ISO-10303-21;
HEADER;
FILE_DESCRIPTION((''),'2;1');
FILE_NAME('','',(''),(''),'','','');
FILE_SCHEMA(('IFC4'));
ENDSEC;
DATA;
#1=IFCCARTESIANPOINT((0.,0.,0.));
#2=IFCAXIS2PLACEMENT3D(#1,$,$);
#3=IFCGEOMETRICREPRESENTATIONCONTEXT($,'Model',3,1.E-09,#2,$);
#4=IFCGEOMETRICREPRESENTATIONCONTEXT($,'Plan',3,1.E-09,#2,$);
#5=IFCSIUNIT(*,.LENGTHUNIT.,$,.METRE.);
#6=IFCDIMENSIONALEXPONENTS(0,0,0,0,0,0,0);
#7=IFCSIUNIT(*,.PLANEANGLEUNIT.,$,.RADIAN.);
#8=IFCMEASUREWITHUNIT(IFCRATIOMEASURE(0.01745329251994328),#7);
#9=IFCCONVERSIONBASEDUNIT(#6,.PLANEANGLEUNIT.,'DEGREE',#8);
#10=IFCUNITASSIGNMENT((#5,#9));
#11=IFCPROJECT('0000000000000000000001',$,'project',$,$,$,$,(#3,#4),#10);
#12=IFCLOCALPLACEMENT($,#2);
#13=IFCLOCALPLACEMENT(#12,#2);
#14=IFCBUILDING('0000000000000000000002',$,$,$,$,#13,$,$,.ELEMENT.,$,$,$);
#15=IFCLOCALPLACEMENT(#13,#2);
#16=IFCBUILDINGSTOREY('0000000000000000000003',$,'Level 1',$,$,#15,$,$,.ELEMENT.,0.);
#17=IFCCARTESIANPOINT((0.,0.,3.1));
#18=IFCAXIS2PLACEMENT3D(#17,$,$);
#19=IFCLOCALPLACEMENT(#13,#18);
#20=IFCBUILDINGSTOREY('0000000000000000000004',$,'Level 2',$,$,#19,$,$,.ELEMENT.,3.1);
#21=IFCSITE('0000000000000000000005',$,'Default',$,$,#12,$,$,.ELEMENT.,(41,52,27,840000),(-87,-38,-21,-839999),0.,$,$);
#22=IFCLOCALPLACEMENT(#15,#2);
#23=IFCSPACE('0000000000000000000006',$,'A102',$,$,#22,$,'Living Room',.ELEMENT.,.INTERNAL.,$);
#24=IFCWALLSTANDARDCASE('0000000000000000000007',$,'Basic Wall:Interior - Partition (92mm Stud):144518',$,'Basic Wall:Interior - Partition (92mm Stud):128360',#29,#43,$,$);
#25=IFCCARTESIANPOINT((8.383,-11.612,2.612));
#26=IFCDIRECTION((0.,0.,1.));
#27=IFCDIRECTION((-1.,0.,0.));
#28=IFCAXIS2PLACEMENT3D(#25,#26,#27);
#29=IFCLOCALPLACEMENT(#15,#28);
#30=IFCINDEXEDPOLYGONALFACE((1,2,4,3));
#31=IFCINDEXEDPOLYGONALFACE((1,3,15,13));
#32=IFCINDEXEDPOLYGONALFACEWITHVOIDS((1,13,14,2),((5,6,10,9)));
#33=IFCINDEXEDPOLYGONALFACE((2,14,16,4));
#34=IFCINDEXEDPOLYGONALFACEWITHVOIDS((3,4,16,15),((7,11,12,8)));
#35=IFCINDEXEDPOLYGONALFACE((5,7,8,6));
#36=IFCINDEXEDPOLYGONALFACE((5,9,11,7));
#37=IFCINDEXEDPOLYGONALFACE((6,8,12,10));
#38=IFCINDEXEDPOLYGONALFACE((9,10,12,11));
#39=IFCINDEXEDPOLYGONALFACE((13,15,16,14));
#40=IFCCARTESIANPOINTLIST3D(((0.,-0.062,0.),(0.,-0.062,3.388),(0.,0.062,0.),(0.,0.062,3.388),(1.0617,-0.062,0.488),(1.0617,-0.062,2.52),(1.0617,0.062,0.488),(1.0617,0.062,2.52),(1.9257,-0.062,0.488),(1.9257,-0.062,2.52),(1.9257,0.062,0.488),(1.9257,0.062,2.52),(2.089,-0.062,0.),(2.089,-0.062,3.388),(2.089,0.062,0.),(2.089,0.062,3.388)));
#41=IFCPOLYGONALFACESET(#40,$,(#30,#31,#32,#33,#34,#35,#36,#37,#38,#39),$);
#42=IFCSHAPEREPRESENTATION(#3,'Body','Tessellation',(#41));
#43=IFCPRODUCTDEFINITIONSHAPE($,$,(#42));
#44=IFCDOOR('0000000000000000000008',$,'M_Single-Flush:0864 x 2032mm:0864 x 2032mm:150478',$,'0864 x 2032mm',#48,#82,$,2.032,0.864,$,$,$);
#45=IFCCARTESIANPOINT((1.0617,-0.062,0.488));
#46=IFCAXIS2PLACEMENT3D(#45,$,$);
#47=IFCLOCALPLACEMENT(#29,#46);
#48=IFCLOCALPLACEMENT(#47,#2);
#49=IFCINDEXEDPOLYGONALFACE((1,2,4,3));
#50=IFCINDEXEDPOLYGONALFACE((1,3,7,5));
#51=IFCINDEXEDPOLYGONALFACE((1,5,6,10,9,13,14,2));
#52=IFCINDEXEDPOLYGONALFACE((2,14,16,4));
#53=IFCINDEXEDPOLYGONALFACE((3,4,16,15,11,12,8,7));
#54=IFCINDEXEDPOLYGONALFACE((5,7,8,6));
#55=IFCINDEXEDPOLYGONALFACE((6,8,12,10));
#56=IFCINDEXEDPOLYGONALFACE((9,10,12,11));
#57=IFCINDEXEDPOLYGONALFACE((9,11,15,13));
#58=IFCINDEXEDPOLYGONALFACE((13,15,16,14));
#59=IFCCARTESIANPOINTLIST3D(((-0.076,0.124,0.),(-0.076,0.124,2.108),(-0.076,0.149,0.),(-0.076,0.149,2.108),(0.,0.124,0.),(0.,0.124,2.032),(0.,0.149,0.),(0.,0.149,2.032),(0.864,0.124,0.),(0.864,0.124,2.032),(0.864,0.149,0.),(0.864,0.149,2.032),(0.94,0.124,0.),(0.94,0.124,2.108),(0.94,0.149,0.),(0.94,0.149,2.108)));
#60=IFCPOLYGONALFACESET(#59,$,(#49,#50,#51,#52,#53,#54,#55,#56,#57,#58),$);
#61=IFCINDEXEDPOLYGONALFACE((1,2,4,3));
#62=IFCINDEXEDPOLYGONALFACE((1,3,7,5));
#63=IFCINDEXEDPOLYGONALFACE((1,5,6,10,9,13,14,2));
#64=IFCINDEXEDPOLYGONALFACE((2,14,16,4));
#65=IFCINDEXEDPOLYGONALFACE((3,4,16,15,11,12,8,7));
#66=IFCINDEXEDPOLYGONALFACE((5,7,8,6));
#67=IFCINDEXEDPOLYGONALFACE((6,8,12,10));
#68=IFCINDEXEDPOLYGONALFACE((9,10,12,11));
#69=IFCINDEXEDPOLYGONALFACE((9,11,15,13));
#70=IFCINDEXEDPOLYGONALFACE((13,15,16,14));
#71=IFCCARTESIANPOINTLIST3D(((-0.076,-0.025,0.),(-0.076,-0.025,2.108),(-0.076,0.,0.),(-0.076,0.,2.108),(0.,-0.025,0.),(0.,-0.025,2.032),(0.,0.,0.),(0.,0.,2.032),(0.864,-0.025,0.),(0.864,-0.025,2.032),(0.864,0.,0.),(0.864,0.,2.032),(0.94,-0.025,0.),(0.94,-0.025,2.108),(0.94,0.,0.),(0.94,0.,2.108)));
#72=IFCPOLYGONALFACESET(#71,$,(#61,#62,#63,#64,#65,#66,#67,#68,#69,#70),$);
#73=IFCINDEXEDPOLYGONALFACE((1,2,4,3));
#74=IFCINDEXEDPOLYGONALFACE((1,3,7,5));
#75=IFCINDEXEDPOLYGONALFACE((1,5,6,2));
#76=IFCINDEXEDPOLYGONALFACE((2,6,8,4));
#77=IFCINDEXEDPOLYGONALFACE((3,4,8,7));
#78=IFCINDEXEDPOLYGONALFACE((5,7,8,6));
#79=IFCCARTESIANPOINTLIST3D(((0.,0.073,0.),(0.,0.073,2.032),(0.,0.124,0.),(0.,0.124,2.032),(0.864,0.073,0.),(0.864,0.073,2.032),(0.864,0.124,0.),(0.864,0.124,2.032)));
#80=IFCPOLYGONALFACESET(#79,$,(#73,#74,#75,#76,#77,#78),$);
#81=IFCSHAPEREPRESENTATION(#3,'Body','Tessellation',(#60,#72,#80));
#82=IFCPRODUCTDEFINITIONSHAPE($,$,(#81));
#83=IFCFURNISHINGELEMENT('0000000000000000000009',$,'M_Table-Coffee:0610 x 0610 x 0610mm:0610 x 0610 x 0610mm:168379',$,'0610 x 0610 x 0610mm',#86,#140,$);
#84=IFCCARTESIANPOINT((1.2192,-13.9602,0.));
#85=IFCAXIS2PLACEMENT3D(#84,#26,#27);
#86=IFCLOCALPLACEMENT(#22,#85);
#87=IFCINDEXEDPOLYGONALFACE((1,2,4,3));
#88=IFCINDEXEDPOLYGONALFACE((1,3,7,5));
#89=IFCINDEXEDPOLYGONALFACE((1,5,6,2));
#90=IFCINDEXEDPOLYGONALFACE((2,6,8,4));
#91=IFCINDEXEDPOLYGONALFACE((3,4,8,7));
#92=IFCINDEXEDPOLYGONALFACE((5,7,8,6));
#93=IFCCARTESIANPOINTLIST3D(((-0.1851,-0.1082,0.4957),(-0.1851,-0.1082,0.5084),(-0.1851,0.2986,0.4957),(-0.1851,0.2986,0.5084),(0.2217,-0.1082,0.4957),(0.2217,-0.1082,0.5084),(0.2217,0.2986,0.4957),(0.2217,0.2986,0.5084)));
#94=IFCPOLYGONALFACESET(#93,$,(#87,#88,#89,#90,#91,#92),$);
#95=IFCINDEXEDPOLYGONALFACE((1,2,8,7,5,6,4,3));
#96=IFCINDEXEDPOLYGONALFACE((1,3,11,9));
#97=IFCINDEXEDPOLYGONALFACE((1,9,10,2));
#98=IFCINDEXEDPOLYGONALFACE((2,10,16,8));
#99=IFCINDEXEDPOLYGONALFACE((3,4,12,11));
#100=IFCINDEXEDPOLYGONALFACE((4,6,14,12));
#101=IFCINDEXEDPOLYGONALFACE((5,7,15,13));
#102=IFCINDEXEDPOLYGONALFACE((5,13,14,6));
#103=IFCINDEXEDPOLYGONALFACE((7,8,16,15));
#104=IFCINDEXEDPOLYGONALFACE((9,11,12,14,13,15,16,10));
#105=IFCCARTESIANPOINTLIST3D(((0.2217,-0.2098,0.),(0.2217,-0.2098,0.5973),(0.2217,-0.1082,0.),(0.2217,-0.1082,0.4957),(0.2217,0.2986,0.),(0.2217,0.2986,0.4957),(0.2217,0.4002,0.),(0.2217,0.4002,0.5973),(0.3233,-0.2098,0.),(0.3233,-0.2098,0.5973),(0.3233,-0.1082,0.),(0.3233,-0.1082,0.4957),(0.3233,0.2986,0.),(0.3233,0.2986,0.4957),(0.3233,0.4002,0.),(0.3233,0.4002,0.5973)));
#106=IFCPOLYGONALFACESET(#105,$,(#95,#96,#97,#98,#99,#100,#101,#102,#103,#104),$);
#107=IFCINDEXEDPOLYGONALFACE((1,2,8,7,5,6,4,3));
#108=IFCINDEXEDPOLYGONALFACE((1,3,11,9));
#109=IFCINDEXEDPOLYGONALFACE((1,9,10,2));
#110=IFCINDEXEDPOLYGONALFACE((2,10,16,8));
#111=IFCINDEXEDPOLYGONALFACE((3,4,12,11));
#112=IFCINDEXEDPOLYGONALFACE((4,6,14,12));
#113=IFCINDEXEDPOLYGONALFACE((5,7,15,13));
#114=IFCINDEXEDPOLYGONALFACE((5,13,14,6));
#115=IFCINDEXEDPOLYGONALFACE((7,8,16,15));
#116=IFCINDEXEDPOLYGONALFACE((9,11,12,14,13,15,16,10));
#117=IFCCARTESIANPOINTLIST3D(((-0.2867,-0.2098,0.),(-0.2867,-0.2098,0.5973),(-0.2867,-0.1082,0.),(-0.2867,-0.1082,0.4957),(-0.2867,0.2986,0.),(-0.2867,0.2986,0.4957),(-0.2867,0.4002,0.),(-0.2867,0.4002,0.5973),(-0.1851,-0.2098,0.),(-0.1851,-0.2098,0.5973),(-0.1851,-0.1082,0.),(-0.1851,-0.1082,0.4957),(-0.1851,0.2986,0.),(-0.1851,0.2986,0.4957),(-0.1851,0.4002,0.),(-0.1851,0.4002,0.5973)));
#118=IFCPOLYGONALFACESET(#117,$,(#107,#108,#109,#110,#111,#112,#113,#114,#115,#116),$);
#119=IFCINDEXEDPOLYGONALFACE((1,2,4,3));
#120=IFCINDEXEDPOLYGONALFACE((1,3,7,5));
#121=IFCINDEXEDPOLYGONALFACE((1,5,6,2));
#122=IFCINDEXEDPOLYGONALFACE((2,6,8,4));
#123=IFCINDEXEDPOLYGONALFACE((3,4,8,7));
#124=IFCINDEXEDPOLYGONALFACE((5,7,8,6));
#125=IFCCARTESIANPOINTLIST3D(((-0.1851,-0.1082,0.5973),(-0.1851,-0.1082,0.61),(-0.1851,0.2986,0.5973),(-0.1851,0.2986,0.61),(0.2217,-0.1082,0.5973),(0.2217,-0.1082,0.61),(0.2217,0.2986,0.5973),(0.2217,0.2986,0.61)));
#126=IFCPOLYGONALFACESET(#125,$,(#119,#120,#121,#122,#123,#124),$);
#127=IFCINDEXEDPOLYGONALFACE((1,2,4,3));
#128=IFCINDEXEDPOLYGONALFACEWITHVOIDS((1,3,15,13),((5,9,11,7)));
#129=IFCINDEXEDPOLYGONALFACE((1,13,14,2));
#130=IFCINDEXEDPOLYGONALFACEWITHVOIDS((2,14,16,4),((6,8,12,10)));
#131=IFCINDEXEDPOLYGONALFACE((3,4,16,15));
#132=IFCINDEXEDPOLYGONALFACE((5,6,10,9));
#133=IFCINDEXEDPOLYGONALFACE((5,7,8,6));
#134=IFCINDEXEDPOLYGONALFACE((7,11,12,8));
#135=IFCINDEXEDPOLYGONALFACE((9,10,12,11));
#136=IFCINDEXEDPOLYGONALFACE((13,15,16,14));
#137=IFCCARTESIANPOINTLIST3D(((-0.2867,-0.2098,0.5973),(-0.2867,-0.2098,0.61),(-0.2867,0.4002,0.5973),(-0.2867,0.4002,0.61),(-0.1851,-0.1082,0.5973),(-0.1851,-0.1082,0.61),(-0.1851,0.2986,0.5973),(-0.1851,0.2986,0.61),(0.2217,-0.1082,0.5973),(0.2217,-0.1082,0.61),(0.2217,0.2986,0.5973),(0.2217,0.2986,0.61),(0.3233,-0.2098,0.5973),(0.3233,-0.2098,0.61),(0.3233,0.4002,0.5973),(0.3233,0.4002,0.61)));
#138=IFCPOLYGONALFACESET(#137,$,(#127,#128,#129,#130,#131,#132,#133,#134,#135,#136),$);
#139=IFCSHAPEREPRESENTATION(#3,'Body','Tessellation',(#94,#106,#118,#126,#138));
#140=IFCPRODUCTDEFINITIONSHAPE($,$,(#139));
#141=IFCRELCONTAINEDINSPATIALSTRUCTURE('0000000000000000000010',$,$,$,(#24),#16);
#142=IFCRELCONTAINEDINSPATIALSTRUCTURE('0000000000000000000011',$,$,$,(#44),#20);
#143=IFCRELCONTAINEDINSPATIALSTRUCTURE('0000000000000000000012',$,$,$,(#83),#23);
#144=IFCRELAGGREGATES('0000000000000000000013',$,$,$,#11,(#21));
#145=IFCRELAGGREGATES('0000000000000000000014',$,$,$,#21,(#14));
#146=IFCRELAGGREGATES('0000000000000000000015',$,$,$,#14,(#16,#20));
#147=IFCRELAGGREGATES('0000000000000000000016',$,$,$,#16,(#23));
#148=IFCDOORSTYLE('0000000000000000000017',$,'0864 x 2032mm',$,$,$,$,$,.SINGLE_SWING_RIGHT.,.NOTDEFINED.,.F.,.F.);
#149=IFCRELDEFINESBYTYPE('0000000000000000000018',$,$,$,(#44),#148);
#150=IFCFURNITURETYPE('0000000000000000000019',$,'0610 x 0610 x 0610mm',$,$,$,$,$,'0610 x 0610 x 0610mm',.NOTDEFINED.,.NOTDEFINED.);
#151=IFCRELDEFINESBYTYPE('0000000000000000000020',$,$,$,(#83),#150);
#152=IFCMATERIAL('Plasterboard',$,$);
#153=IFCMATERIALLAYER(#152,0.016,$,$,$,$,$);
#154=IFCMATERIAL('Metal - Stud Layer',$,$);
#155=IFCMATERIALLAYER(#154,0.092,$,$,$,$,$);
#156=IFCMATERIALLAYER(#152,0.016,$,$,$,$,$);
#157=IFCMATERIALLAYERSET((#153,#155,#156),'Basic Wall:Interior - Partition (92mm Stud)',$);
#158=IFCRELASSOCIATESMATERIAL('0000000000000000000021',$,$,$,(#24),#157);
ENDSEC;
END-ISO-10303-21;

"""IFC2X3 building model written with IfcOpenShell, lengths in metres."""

from ifc_helpers import new_model, entity, si_unit, converted_unit, frame, frame_2d, origin, origin_2d_with_axis, place, context, project, spatial, polyline, rectangle, outline, extrude, source, transform, mapped, material, layer, layer_set, layer_usage, type_object, type_shapes, element, fill, save


model = new_model("IFC2X3")

# Units and contexts
model_context = context("Model", 3, precision=1e-09, world=origin())
plan_context = context("Plan", 3, precision=1e-09, world=origin())
ifc_project = project(units=[si_unit("LENGTHUNIT", "METRE"), converted_unit("PLANEANGLEUNIT", "DEGREE", entity("IfcRatioMeasure", 0.01745329251994328), si_unit("PLANEANGLEUNIT", "RADIAN"), dimensions=[0, 0, 0, 0, 0, 0, 0])], contexts=[model_context, plan_context])

# Site, building, storey
site_placement = place(None, origin())
site = spatial("IfcSite", under=ifc_project, at=site_placement, Name="Default", CompositionType="ELEMENT", RefLatitude=(41, 52, 27, 840000), RefLongitude=(-87, -38, -21, -839999), RefElevation=0.0)
building_placement = place(site_placement, origin())
building = spatial("IfcBuilding", under=site, at=building_placement, CompositionType="ELEMENT")
storey_1_placement = place(building_placement, origin())
storey_1 = spatial("IfcBuildingStorey", under=building, at=storey_1_placement, Name="Level 1", CompositionType="ELEMENT", Elevation=0.0)

# Shared definitions
ifc_material_1 = material(Name="Plasterboard")
ifc_layer_1 = layer(ifc_material_1, 0.016)
ifc_material_2 = material(Name="Metal - Stud Layer")
ifc_layer_2 = layer(ifc_material_2, 0.092)
ifc_layer_3 = layer(ifc_material_1, 0.016)
ifc_layer_set_1 = layer_set([ifc_layer_1, ifc_layer_2, ifc_layer_3], Name="Basic Wall:Interior - Partition (92mm Stud)")

# Wall, opening
ifc_layer_usage_1 = layer_usage(ifc_layer_set_1, "AXIS2", "NEGATIVE", 0.062)
wall_1_placement = place(storey_1_placement, frame((8.383, -11.612, 2.612), z_axis=(0.0, 0.0, 1.0), x_axis=(-1.0, 0.0, 0.0)))
wall_1 = element("IfcWallStandardCase", 1, at=wall_1_placement, inside=storey_1, material=ifc_layer_usage_1, Name="Basic Wall:Interior - Partition (92mm Stud):144518", ObjectType="Basic Wall:Interior - Partition (92mm Stud):128360", context=model_context, shape_type="SweptSolid", body=[
    extrude(rectangle(XDim=2.089, YDim=0.124, at=frame_2d((1.0445, 0.0), x_axis=(-1.0, 0.0))), origin(), (0.0, 0.0, 1.0), 3.388),
])
opening_1_placement = place(wall_1_placement, frame((1.0617, -0.062, 0.488)))
opening_1 = element("IfcOpeningElement", 2, at=opening_1_placement, cuts=wall_1, ObjectType="Opening", context=model_context, shape_type="SweptSolid", body=[
    extrude(rectangle(XDim=0.864, YDim=2.032, at=frame_2d((1.016, 0.432), x_axis=(0.0, 1.0))), frame((0.0, 0.0, 0.0), z_axis=(0.0, 1.0, 0.0), x_axis=(0.0, 0.0, 1.0)), (0.0, 0.0, 1.0), 0.124),
])

# Shared definitions
storey_2_placement = place(building_placement, frame((0.0, 0.0, 3.1)))
storey_2 = spatial("IfcBuildingStorey", under=building, at=storey_2_placement, Name="Level 2", CompositionType="ELEMENT", Elevation=3.1)

# Door
door_style_1 = type_object("IfcDoorStyle", Name="0864 x 2032mm", ConstructionType="NOTDEFINED", OperationType="SINGLE_SWING_RIGHT", ParameterTakesPrecedence=False, Sizeable=False)
shared_shape_1 = source(origin(), model_context, "Body", "SweptSolid", [
    extrude(outline(polyline([(-0.508, -1.073), (0.508, -1.073), (0.508, 1.035), (0.432, 1.035), (0.432, -0.997), (-0.432, -0.997), (-0.432, 1.035), (-0.508, 1.035), (-0.508, -1.073)])), frame((0.432, 0.124, 1.035), z_axis=(0.0, 1.0, 0.0), x_axis=(1.0, 0.0, 0.0)), (0.0, 0.0, 1.0), 0.025),
    extrude(outline(polyline([(-1.073, -0.508), (1.035, -0.508), (1.035, -0.432), (-0.997, -0.432), (-0.997, 0.432), (1.035, 0.432), (1.035, 0.508), (-1.073, 0.508), (-1.073, -0.508)])), frame((0.432, -0.025, 1.035), z_axis=(0.0, 1.0, 0.0), x_axis=(0.0, 0.0, -1.0)), (0.0, 0.0, 1.0), 0.025),
    extrude(rectangle(XDim=0.051, YDim=0.864, at=origin_2d_with_axis()), frame((0.432, 0.0985, 0.0), z_axis=(0.0, 0.0, 1.0), x_axis=(0.0, 1.0, 0.0)), (0.0, 0.0, 1.0), 2.032),
])
type_shapes(door_style_1, [shared_shape_1])
door_1_placement = place(opening_1_placement, origin())
door_1 = element("IfcDoor", 3, at=door_1_placement, inside=storey_2, type_object=door_style_1, Name="M_Single-Flush:0864 x 2032mm:0864 x 2032mm:150478", ObjectType="0864 x 2032mm", OverallHeight=2.032, OverallWidth=0.864, context=model_context, shape_type="MappedRepresentation", body=[
    mapped(shared_shape_1, transform((0.0, 0.0, 0.0), scale=1.0)),
])
fill(opening_1, door_1)

# Shared definitions
space_1_placement = place(storey_1_placement, origin())
space_1 = spatial("IfcSpace", under=storey_1, at=space_1_placement, Name="A102", LongName="Living Room", CompositionType="ELEMENT", InteriorOrExteriorSpace="INTERNAL")

# Furnishing element
furniture_type_1 = type_object("IfcFurnitureType", Name="0610 x 0610 x 0610mm", ElementType="0610 x 0610 x 0610mm", AssemblyPlace="NOTDEFINED")
shared_shape_2 = source(origin(), model_context, "Body", "SweptSolid", [
    extrude(rectangle(XDim=0.4068, YDim=0.4068, at=origin_2d_with_axis()), frame((0.0183, 0.0952, 0.4957), z_axis=(0.0, 0.0, 1.0), x_axis=(-1.0, 0.0, 0.0)), (0.0, 0.0, 1.0), 0.0127),
    extrude(outline(polyline([(-0.2732, -0.305), (0.324, -0.305), (0.324, 0.305), (-0.2732, 0.305), (-0.2732, 0.2034), (0.2225, 0.2034), (0.2225, -0.2034), (-0.2732, -0.2034), (-0.2732, -0.305)])), frame((0.2217, 0.0952, 0.2732), z_axis=(1.0, 0.0, 0.0), x_axis=(0.0, 0.0, 1.0)), (0.0, 0.0, 1.0), 0.1016),
    extrude(outline(polyline([(-0.305, -0.3241), (0.305, -0.3241), (0.305, 0.2733), (0.2034, 0.2733), (0.2034, -0.2224), (-0.2034, -0.2224), (-0.2034, 0.2733), (-0.305, 0.2733), (-0.305, -0.3241)])), frame((-0.2867, 0.0952, 0.2733), z_axis=(1.0, 0.0, 0.0), x_axis=(0.0, -1.0, 0.0)), (0.0, 0.0, 1.0), 0.1016),
    extrude(rectangle(XDim=0.4068, YDim=0.4068, at=origin_2d_with_axis()), frame((0.0183, 0.0952, 0.5973), z_axis=(0.0, 0.0, 1.0), x_axis=(-1.0, 0.0, 0.0)), (0.0, 0.0, 1.0), 0.0127),
    extrude(outline(polyline([(-0.305, -0.305), (0.305, -0.305), (0.305, 0.305), (-0.305, 0.305), (-0.305, -0.305)]), holes=[polyline([(-0.2034, -0.2034), (-0.2034, 0.2034), (0.2034, 0.2034), (0.2034, -0.2034), (-0.2034, -0.2034)])]), frame((0.0183, 0.0952, 0.5973), z_axis=(0.0, 0.0, 1.0), x_axis=(-1.0, 0.0, 0.0)), (0.0, 0.0, 1.0), 0.0127),
])
type_shapes(furniture_type_1, [shared_shape_2])
furnishing_1_placement = place(space_1_placement, frame((1.2192, -13.9602, 0.0), z_axis=(0.0, 0.0, 1.0), x_axis=(-1.0, 0.0, 0.0)))
element("IfcFurnishingElement", 4, at=furnishing_1_placement, inside=space_1, type_object=furniture_type_1, Name="M_Table-Coffee:0610 x 0610 x 0610mm:0610 x 0610 x 0610mm:168379", ObjectType="0610 x 0610 x 0610mm", context=model_context, shape_type="MappedRepresentation", body=[
    mapped(shared_shape_2, transform((0.0, 0.0, 0.0), scale=1.0)),
])

save(model, "model.ifc")
